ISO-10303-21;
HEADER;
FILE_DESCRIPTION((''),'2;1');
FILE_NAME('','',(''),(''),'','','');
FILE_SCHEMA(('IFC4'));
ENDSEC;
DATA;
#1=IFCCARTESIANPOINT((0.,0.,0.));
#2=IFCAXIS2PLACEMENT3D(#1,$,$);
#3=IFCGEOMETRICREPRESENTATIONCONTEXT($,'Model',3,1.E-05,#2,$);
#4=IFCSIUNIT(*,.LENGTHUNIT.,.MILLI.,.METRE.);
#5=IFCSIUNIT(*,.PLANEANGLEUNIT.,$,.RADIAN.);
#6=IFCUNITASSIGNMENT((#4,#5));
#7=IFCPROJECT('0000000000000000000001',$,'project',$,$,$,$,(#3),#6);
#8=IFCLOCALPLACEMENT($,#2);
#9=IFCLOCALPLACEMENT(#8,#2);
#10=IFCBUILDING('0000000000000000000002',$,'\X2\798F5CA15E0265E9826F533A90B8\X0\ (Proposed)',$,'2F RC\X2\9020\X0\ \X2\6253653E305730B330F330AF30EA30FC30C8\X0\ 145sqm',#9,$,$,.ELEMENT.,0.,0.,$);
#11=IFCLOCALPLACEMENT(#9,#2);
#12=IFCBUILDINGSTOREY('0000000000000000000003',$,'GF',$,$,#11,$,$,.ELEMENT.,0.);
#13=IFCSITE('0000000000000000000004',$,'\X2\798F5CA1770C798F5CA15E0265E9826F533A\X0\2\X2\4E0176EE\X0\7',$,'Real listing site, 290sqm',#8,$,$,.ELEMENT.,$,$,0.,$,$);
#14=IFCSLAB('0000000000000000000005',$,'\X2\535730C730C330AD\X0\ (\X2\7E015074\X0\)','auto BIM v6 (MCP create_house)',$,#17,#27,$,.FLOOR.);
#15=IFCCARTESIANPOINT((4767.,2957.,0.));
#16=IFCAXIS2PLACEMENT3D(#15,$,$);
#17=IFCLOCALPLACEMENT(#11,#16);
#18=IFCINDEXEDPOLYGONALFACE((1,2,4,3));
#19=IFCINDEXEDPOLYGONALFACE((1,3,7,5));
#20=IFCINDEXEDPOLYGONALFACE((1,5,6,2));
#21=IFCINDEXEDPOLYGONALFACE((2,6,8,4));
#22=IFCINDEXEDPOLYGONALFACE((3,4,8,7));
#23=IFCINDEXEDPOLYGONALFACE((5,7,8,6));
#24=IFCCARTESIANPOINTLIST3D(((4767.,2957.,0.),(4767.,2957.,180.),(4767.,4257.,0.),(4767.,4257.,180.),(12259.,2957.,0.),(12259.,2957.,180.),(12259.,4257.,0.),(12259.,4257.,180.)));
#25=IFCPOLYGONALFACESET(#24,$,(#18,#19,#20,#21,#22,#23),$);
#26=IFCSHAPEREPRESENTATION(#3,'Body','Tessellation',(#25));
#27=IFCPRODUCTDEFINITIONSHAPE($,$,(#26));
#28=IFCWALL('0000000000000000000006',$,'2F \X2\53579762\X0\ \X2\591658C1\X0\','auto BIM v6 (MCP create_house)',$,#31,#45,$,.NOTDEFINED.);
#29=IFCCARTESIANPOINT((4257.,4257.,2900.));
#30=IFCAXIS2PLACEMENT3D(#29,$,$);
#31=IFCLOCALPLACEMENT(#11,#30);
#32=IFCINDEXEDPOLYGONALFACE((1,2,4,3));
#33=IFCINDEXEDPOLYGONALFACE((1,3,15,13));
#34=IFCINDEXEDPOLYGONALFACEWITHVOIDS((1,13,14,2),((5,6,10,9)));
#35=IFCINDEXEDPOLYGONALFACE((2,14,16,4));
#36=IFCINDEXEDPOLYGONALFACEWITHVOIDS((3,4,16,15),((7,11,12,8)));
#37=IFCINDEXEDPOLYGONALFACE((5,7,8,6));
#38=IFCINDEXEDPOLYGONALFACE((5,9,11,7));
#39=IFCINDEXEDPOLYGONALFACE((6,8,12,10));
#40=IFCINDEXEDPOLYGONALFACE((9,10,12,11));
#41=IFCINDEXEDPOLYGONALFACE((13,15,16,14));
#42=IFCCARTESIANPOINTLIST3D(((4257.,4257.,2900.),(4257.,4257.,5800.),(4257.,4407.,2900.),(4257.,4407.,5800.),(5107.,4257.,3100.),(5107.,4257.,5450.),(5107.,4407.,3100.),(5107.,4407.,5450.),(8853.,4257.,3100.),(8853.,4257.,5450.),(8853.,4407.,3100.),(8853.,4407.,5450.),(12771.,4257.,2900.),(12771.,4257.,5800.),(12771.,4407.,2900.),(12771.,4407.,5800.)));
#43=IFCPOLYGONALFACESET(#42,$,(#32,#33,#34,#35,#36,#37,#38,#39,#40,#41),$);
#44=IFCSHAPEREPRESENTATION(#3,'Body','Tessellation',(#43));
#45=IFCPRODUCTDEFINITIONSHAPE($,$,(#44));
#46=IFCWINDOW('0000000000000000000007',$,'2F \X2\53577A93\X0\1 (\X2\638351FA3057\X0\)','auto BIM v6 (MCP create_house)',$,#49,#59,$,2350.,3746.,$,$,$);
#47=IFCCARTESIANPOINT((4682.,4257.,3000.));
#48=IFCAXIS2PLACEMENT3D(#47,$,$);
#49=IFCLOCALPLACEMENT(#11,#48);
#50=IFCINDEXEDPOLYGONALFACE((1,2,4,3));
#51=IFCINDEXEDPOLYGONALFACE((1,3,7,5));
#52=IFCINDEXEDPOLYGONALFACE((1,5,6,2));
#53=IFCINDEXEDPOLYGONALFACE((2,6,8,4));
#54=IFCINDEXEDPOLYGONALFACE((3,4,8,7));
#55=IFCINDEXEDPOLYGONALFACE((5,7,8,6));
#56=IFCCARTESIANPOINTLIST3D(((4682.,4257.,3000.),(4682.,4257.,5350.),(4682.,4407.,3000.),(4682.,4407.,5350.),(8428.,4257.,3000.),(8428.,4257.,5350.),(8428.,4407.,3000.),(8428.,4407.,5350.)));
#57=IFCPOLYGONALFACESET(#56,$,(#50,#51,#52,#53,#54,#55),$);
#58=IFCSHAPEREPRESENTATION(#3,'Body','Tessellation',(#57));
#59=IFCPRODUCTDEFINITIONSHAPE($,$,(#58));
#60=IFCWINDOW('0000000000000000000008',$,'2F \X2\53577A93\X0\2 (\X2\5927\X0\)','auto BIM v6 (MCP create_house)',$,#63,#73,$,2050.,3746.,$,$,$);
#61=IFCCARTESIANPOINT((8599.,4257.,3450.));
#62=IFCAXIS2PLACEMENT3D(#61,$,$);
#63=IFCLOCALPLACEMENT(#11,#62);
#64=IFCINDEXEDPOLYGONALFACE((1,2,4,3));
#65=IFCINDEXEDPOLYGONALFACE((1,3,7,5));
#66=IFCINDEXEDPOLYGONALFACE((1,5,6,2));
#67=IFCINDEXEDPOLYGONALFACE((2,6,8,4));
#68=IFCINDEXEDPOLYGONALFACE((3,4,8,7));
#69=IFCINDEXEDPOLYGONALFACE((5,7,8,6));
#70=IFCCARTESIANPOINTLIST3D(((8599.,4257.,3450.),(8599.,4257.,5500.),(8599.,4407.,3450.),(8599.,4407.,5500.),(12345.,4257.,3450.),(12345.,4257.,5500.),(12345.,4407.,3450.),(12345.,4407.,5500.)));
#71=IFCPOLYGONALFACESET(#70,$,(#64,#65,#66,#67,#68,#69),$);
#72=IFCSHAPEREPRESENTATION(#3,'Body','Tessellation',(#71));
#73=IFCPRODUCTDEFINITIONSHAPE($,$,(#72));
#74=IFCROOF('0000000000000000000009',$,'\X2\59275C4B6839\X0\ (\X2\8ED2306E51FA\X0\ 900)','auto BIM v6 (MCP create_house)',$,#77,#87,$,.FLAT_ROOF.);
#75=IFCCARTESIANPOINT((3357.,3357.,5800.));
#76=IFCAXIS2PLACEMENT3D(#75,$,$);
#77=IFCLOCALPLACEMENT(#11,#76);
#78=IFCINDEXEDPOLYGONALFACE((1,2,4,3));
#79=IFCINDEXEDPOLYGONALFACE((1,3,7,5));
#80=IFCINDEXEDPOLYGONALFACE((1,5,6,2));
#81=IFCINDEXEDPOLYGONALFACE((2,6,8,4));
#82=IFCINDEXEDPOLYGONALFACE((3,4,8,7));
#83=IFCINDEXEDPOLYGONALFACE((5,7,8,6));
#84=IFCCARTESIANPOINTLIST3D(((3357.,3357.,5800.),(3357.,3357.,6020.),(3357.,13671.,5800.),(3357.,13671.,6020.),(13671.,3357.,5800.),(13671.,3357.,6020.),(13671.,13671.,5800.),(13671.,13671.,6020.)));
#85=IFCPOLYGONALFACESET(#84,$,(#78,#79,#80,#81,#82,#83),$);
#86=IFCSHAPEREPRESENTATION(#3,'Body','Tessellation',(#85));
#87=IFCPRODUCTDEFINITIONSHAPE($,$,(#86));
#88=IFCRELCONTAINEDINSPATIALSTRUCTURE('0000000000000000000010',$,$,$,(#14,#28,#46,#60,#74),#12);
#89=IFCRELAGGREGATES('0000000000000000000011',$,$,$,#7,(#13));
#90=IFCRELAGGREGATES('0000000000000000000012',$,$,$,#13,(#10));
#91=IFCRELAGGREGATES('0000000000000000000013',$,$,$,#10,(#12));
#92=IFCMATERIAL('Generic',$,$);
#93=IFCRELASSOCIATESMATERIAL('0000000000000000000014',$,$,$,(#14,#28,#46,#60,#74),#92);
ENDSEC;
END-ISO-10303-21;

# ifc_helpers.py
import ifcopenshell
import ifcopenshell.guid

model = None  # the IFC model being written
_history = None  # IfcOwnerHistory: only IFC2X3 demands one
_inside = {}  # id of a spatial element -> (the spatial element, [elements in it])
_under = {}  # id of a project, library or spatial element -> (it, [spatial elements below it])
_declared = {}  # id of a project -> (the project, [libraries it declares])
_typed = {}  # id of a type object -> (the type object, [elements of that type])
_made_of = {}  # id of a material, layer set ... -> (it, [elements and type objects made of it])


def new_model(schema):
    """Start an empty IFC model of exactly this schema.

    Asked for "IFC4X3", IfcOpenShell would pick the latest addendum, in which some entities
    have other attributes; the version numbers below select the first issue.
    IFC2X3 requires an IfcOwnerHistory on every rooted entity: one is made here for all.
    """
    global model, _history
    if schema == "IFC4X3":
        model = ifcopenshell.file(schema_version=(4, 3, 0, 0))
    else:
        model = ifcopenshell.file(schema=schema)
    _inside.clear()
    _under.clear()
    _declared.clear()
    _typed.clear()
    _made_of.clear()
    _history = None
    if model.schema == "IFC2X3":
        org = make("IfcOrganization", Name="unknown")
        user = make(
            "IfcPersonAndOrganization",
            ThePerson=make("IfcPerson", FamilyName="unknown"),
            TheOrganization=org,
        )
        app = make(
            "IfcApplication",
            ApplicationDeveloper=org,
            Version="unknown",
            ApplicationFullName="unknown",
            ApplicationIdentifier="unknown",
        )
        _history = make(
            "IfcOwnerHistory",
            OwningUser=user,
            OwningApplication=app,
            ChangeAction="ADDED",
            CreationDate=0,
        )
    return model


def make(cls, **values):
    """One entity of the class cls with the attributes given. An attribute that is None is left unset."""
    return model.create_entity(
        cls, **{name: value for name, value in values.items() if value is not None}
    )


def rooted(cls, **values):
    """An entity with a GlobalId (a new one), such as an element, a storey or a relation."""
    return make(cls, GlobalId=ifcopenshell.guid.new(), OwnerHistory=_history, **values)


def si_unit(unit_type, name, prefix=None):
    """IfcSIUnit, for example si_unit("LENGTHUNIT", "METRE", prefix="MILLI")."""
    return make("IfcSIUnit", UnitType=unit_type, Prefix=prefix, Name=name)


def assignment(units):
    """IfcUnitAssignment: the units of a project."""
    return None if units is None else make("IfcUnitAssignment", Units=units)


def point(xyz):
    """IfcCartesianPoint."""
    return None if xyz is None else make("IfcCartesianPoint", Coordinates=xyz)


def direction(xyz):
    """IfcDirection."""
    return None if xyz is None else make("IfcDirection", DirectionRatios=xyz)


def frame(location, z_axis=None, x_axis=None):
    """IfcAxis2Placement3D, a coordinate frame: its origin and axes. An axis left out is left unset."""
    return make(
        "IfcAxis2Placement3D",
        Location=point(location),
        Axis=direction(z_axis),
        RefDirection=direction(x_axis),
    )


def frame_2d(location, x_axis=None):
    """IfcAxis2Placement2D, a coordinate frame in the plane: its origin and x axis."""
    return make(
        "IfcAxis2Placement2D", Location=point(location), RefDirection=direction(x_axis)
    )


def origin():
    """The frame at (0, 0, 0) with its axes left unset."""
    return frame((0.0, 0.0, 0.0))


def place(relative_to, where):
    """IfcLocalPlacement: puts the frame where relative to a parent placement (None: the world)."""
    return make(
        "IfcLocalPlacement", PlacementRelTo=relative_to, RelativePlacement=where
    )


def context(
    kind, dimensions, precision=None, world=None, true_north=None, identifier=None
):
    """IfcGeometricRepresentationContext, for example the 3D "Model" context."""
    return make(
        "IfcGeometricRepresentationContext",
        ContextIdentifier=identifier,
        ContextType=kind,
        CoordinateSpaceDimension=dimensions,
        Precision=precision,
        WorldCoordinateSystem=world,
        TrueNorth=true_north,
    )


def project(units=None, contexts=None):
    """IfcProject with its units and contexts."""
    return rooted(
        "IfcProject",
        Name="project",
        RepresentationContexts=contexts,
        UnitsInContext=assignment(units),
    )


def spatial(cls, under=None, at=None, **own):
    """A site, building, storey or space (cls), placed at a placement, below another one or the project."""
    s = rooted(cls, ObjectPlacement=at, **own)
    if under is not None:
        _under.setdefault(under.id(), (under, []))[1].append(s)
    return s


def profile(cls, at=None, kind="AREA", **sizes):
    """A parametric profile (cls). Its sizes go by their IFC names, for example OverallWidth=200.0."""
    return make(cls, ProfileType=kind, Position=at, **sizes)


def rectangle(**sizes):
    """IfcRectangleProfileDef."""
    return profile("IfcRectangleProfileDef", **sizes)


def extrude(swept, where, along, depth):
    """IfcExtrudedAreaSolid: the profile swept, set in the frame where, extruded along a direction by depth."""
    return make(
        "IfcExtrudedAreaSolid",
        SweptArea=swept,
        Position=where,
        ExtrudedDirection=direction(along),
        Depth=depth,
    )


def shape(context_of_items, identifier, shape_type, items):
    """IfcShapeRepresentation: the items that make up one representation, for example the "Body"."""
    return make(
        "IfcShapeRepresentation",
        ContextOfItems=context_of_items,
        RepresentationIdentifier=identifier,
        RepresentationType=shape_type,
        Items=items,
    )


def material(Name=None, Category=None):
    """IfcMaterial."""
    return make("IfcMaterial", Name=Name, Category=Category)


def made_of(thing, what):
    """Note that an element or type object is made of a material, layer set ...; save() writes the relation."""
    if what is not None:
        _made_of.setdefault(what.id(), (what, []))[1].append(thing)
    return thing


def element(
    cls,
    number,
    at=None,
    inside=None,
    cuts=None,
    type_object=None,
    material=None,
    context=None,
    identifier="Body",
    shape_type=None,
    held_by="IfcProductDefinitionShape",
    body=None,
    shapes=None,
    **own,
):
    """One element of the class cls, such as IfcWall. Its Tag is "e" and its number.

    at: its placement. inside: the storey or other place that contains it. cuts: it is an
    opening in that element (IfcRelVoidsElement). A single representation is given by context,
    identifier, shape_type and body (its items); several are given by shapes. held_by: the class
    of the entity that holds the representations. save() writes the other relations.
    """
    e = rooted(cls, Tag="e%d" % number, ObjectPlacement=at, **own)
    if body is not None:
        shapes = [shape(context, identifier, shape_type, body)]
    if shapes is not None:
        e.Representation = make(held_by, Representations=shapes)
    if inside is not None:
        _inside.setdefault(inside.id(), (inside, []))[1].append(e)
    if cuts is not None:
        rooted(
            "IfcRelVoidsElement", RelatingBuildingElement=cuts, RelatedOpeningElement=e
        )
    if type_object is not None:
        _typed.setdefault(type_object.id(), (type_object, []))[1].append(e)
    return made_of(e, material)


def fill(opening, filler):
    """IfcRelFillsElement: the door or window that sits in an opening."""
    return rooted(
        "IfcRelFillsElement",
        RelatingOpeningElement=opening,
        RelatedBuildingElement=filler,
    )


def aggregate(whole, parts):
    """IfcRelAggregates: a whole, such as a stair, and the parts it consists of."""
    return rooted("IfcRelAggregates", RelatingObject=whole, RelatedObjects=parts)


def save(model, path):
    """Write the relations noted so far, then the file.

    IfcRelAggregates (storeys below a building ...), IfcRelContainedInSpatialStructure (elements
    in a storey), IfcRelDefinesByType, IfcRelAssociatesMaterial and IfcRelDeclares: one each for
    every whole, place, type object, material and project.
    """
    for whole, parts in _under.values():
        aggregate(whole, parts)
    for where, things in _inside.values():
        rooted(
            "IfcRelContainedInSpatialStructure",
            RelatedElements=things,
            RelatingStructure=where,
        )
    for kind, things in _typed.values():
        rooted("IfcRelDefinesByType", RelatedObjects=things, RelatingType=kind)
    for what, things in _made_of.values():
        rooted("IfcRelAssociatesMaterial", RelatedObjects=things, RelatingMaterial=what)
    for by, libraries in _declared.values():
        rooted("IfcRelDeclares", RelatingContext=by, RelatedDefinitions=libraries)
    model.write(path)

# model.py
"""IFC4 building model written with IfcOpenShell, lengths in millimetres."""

from ifc_helpers import new_model, si_unit, frame, frame_2d, origin, place, context, project, spatial, rectangle, extrude, material, element, fill, save


model = new_model("IFC4")

# Units and contexts
model_context = context("Model", 3, precision=1e-05, world=origin())
ifc_project = project(units=[si_unit("LENGTHUNIT", "METRE", prefix="MILLI"), si_unit("PLANEANGLEUNIT", "RADIAN")], contexts=[model_context])

# Site, building, storey
site_placement = place(None, origin())
site = spatial("IfcSite", under=ifc_project, at=site_placement, Name="福岡県福岡市早良区2丁目7", ObjectType="Real listing site, 290sqm", CompositionType="ELEMENT", RefElevation=0.0)
building_placement = place(site_placement, origin())
building = spatial("IfcBuilding", under=site, at=building_placement, Name="福岡市早良区邸 (Proposed)", ObjectType="2F RC造 打放しコンクリート 145sqm", CompositionType="ELEMENT", ElevationOfRefHeight=0.0, ElevationOfTerrain=0.0)
storey_placement = place(building_placement, origin())
storey = spatial("IfcBuildingStorey", under=building, at=storey_placement, Name="GF", CompositionType="ELEMENT", Elevation=0.0)

# Slab
ifc_material = material(Name="Generic")
slab_1_placement = place(storey_placement, frame((4767.0, 2957.0, 0.0)))
element("IfcSlab", 1, at=slab_1_placement, inside=storey, material=ifc_material, Name="南デッキ (縁側)", Description="auto BIM v6 (MCP create_house)", PredefinedType="FLOOR", context=model_context, shape_type="SweptSolid", body=[
    extrude(rectangle(XDim=7492.0, YDim=1300.0, at=frame_2d((3746.0, 650.0))), frame((4767.0, 2957.0, 0.0)), (0.0, 0.0, 1.0), 180.0),
])

# Wall, openings, windows
wall_1_placement = place(storey_placement, frame((4257.0, 4257.0, 2900.0)))
wall_1 = element("IfcWall", 2, at=wall_1_placement, inside=storey, material=ifc_material, Name="2F 南面 外壁", Description="auto BIM v6 (MCP create_house)", PredefinedType="NOTDEFINED", context=model_context, shape_type="SweptSolid", body=[
    extrude(rectangle(XDim=8514.0, YDim=150.0, at=frame_2d((4257.0, 75.0))), frame((4257.0, 4257.0, 2900.0)), (0.0, 0.0, 1.0), 2900.0),
])
opening_1_placement = place(storey_placement, frame((4682.0, 4257.0, 3000.0)))
opening_1 = element("IfcOpeningElement", 3, at=opening_1_placement, cuts=wall_1, PredefinedType="NOTDEFINED", context=model_context, shape_type="SweptSolid", body=[
    extrude(rectangle(XDim=3746.0, YDim=150.0, at=frame_2d((1873.0, 75.0))), frame((4682.0, 4257.0, 3000.0)), (0.0, 0.0, 1.0), 2350.0),
])
opening_2_placement = place(storey_placement, frame((8599.0, 4257.0, 3450.0)))
opening_2 = element("IfcOpeningElement", 4, at=opening_2_placement, cuts=wall_1, PredefinedType="NOTDEFINED", context=model_context, shape_type="SweptSolid", body=[
    extrude(rectangle(XDim=3746.0, YDim=150.0, at=frame_2d((1873.0, 75.0))), frame((8599.0, 4257.0, 3450.0)), (0.0, 0.0, 1.0), 2050.0),
])
window_1_placement = place(storey_placement, frame((4682.0, 4257.0, 3000.0)))
window_1 = element("IfcWindow", 5, at=window_1_placement, inside=storey, material=ifc_material, Name="2F 南窓1 (掃出し)", Description="auto BIM v6 (MCP create_house)", OverallHeight=2350.0, OverallWidth=3746.0, context=model_context, shape_type="SweptSolid", body=[
    extrude(rectangle(XDim=3746.0, YDim=150.0, at=frame_2d((1873.0, 75.0))), frame((4682.0, 4257.0, 3000.0)), (0.0, 0.0, 1.0), 2350.0),
])
fill(opening_1, window_1)
window_2_placement = place(storey_placement, frame((8599.0, 4257.0, 3450.0)))
window_2 = element("IfcWindow", 6, at=window_2_placement, inside=storey, material=ifc_material, Name="2F 南窓2 (大)", Description="auto BIM v6 (MCP create_house)", OverallHeight=2050.0, OverallWidth=3746.0, context=model_context, shape_type="SweptSolid", body=[
    extrude(rectangle(XDim=3746.0, YDim=150.0, at=frame_2d((1873.0, 75.0))), frame((8599.0, 4257.0, 3450.0)), (0.0, 0.0, 1.0), 2050.0),
])
fill(opening_2, window_2)

# Roof
roof_placement = place(storey_placement, frame((3357.0, 3357.0, 5800.0)))
element("IfcRoof", 7, at=roof_placement, inside=storey, material=ifc_material, Name="大屋根 (軒の出 900)", Description="auto BIM v6 (MCP create_house)", PredefinedType="FLAT_ROOF", context=model_context, shape_type="SweptSolid", body=[
    extrude(rectangle(XDim=10314.0, YDim=10314.0, at=frame_2d((5157.0, 5157.0))), frame((3357.0, 3357.0, 5800.0)), (0.0, 0.0, 1.0), 220.0),
])

save(model, "model.ifc")
